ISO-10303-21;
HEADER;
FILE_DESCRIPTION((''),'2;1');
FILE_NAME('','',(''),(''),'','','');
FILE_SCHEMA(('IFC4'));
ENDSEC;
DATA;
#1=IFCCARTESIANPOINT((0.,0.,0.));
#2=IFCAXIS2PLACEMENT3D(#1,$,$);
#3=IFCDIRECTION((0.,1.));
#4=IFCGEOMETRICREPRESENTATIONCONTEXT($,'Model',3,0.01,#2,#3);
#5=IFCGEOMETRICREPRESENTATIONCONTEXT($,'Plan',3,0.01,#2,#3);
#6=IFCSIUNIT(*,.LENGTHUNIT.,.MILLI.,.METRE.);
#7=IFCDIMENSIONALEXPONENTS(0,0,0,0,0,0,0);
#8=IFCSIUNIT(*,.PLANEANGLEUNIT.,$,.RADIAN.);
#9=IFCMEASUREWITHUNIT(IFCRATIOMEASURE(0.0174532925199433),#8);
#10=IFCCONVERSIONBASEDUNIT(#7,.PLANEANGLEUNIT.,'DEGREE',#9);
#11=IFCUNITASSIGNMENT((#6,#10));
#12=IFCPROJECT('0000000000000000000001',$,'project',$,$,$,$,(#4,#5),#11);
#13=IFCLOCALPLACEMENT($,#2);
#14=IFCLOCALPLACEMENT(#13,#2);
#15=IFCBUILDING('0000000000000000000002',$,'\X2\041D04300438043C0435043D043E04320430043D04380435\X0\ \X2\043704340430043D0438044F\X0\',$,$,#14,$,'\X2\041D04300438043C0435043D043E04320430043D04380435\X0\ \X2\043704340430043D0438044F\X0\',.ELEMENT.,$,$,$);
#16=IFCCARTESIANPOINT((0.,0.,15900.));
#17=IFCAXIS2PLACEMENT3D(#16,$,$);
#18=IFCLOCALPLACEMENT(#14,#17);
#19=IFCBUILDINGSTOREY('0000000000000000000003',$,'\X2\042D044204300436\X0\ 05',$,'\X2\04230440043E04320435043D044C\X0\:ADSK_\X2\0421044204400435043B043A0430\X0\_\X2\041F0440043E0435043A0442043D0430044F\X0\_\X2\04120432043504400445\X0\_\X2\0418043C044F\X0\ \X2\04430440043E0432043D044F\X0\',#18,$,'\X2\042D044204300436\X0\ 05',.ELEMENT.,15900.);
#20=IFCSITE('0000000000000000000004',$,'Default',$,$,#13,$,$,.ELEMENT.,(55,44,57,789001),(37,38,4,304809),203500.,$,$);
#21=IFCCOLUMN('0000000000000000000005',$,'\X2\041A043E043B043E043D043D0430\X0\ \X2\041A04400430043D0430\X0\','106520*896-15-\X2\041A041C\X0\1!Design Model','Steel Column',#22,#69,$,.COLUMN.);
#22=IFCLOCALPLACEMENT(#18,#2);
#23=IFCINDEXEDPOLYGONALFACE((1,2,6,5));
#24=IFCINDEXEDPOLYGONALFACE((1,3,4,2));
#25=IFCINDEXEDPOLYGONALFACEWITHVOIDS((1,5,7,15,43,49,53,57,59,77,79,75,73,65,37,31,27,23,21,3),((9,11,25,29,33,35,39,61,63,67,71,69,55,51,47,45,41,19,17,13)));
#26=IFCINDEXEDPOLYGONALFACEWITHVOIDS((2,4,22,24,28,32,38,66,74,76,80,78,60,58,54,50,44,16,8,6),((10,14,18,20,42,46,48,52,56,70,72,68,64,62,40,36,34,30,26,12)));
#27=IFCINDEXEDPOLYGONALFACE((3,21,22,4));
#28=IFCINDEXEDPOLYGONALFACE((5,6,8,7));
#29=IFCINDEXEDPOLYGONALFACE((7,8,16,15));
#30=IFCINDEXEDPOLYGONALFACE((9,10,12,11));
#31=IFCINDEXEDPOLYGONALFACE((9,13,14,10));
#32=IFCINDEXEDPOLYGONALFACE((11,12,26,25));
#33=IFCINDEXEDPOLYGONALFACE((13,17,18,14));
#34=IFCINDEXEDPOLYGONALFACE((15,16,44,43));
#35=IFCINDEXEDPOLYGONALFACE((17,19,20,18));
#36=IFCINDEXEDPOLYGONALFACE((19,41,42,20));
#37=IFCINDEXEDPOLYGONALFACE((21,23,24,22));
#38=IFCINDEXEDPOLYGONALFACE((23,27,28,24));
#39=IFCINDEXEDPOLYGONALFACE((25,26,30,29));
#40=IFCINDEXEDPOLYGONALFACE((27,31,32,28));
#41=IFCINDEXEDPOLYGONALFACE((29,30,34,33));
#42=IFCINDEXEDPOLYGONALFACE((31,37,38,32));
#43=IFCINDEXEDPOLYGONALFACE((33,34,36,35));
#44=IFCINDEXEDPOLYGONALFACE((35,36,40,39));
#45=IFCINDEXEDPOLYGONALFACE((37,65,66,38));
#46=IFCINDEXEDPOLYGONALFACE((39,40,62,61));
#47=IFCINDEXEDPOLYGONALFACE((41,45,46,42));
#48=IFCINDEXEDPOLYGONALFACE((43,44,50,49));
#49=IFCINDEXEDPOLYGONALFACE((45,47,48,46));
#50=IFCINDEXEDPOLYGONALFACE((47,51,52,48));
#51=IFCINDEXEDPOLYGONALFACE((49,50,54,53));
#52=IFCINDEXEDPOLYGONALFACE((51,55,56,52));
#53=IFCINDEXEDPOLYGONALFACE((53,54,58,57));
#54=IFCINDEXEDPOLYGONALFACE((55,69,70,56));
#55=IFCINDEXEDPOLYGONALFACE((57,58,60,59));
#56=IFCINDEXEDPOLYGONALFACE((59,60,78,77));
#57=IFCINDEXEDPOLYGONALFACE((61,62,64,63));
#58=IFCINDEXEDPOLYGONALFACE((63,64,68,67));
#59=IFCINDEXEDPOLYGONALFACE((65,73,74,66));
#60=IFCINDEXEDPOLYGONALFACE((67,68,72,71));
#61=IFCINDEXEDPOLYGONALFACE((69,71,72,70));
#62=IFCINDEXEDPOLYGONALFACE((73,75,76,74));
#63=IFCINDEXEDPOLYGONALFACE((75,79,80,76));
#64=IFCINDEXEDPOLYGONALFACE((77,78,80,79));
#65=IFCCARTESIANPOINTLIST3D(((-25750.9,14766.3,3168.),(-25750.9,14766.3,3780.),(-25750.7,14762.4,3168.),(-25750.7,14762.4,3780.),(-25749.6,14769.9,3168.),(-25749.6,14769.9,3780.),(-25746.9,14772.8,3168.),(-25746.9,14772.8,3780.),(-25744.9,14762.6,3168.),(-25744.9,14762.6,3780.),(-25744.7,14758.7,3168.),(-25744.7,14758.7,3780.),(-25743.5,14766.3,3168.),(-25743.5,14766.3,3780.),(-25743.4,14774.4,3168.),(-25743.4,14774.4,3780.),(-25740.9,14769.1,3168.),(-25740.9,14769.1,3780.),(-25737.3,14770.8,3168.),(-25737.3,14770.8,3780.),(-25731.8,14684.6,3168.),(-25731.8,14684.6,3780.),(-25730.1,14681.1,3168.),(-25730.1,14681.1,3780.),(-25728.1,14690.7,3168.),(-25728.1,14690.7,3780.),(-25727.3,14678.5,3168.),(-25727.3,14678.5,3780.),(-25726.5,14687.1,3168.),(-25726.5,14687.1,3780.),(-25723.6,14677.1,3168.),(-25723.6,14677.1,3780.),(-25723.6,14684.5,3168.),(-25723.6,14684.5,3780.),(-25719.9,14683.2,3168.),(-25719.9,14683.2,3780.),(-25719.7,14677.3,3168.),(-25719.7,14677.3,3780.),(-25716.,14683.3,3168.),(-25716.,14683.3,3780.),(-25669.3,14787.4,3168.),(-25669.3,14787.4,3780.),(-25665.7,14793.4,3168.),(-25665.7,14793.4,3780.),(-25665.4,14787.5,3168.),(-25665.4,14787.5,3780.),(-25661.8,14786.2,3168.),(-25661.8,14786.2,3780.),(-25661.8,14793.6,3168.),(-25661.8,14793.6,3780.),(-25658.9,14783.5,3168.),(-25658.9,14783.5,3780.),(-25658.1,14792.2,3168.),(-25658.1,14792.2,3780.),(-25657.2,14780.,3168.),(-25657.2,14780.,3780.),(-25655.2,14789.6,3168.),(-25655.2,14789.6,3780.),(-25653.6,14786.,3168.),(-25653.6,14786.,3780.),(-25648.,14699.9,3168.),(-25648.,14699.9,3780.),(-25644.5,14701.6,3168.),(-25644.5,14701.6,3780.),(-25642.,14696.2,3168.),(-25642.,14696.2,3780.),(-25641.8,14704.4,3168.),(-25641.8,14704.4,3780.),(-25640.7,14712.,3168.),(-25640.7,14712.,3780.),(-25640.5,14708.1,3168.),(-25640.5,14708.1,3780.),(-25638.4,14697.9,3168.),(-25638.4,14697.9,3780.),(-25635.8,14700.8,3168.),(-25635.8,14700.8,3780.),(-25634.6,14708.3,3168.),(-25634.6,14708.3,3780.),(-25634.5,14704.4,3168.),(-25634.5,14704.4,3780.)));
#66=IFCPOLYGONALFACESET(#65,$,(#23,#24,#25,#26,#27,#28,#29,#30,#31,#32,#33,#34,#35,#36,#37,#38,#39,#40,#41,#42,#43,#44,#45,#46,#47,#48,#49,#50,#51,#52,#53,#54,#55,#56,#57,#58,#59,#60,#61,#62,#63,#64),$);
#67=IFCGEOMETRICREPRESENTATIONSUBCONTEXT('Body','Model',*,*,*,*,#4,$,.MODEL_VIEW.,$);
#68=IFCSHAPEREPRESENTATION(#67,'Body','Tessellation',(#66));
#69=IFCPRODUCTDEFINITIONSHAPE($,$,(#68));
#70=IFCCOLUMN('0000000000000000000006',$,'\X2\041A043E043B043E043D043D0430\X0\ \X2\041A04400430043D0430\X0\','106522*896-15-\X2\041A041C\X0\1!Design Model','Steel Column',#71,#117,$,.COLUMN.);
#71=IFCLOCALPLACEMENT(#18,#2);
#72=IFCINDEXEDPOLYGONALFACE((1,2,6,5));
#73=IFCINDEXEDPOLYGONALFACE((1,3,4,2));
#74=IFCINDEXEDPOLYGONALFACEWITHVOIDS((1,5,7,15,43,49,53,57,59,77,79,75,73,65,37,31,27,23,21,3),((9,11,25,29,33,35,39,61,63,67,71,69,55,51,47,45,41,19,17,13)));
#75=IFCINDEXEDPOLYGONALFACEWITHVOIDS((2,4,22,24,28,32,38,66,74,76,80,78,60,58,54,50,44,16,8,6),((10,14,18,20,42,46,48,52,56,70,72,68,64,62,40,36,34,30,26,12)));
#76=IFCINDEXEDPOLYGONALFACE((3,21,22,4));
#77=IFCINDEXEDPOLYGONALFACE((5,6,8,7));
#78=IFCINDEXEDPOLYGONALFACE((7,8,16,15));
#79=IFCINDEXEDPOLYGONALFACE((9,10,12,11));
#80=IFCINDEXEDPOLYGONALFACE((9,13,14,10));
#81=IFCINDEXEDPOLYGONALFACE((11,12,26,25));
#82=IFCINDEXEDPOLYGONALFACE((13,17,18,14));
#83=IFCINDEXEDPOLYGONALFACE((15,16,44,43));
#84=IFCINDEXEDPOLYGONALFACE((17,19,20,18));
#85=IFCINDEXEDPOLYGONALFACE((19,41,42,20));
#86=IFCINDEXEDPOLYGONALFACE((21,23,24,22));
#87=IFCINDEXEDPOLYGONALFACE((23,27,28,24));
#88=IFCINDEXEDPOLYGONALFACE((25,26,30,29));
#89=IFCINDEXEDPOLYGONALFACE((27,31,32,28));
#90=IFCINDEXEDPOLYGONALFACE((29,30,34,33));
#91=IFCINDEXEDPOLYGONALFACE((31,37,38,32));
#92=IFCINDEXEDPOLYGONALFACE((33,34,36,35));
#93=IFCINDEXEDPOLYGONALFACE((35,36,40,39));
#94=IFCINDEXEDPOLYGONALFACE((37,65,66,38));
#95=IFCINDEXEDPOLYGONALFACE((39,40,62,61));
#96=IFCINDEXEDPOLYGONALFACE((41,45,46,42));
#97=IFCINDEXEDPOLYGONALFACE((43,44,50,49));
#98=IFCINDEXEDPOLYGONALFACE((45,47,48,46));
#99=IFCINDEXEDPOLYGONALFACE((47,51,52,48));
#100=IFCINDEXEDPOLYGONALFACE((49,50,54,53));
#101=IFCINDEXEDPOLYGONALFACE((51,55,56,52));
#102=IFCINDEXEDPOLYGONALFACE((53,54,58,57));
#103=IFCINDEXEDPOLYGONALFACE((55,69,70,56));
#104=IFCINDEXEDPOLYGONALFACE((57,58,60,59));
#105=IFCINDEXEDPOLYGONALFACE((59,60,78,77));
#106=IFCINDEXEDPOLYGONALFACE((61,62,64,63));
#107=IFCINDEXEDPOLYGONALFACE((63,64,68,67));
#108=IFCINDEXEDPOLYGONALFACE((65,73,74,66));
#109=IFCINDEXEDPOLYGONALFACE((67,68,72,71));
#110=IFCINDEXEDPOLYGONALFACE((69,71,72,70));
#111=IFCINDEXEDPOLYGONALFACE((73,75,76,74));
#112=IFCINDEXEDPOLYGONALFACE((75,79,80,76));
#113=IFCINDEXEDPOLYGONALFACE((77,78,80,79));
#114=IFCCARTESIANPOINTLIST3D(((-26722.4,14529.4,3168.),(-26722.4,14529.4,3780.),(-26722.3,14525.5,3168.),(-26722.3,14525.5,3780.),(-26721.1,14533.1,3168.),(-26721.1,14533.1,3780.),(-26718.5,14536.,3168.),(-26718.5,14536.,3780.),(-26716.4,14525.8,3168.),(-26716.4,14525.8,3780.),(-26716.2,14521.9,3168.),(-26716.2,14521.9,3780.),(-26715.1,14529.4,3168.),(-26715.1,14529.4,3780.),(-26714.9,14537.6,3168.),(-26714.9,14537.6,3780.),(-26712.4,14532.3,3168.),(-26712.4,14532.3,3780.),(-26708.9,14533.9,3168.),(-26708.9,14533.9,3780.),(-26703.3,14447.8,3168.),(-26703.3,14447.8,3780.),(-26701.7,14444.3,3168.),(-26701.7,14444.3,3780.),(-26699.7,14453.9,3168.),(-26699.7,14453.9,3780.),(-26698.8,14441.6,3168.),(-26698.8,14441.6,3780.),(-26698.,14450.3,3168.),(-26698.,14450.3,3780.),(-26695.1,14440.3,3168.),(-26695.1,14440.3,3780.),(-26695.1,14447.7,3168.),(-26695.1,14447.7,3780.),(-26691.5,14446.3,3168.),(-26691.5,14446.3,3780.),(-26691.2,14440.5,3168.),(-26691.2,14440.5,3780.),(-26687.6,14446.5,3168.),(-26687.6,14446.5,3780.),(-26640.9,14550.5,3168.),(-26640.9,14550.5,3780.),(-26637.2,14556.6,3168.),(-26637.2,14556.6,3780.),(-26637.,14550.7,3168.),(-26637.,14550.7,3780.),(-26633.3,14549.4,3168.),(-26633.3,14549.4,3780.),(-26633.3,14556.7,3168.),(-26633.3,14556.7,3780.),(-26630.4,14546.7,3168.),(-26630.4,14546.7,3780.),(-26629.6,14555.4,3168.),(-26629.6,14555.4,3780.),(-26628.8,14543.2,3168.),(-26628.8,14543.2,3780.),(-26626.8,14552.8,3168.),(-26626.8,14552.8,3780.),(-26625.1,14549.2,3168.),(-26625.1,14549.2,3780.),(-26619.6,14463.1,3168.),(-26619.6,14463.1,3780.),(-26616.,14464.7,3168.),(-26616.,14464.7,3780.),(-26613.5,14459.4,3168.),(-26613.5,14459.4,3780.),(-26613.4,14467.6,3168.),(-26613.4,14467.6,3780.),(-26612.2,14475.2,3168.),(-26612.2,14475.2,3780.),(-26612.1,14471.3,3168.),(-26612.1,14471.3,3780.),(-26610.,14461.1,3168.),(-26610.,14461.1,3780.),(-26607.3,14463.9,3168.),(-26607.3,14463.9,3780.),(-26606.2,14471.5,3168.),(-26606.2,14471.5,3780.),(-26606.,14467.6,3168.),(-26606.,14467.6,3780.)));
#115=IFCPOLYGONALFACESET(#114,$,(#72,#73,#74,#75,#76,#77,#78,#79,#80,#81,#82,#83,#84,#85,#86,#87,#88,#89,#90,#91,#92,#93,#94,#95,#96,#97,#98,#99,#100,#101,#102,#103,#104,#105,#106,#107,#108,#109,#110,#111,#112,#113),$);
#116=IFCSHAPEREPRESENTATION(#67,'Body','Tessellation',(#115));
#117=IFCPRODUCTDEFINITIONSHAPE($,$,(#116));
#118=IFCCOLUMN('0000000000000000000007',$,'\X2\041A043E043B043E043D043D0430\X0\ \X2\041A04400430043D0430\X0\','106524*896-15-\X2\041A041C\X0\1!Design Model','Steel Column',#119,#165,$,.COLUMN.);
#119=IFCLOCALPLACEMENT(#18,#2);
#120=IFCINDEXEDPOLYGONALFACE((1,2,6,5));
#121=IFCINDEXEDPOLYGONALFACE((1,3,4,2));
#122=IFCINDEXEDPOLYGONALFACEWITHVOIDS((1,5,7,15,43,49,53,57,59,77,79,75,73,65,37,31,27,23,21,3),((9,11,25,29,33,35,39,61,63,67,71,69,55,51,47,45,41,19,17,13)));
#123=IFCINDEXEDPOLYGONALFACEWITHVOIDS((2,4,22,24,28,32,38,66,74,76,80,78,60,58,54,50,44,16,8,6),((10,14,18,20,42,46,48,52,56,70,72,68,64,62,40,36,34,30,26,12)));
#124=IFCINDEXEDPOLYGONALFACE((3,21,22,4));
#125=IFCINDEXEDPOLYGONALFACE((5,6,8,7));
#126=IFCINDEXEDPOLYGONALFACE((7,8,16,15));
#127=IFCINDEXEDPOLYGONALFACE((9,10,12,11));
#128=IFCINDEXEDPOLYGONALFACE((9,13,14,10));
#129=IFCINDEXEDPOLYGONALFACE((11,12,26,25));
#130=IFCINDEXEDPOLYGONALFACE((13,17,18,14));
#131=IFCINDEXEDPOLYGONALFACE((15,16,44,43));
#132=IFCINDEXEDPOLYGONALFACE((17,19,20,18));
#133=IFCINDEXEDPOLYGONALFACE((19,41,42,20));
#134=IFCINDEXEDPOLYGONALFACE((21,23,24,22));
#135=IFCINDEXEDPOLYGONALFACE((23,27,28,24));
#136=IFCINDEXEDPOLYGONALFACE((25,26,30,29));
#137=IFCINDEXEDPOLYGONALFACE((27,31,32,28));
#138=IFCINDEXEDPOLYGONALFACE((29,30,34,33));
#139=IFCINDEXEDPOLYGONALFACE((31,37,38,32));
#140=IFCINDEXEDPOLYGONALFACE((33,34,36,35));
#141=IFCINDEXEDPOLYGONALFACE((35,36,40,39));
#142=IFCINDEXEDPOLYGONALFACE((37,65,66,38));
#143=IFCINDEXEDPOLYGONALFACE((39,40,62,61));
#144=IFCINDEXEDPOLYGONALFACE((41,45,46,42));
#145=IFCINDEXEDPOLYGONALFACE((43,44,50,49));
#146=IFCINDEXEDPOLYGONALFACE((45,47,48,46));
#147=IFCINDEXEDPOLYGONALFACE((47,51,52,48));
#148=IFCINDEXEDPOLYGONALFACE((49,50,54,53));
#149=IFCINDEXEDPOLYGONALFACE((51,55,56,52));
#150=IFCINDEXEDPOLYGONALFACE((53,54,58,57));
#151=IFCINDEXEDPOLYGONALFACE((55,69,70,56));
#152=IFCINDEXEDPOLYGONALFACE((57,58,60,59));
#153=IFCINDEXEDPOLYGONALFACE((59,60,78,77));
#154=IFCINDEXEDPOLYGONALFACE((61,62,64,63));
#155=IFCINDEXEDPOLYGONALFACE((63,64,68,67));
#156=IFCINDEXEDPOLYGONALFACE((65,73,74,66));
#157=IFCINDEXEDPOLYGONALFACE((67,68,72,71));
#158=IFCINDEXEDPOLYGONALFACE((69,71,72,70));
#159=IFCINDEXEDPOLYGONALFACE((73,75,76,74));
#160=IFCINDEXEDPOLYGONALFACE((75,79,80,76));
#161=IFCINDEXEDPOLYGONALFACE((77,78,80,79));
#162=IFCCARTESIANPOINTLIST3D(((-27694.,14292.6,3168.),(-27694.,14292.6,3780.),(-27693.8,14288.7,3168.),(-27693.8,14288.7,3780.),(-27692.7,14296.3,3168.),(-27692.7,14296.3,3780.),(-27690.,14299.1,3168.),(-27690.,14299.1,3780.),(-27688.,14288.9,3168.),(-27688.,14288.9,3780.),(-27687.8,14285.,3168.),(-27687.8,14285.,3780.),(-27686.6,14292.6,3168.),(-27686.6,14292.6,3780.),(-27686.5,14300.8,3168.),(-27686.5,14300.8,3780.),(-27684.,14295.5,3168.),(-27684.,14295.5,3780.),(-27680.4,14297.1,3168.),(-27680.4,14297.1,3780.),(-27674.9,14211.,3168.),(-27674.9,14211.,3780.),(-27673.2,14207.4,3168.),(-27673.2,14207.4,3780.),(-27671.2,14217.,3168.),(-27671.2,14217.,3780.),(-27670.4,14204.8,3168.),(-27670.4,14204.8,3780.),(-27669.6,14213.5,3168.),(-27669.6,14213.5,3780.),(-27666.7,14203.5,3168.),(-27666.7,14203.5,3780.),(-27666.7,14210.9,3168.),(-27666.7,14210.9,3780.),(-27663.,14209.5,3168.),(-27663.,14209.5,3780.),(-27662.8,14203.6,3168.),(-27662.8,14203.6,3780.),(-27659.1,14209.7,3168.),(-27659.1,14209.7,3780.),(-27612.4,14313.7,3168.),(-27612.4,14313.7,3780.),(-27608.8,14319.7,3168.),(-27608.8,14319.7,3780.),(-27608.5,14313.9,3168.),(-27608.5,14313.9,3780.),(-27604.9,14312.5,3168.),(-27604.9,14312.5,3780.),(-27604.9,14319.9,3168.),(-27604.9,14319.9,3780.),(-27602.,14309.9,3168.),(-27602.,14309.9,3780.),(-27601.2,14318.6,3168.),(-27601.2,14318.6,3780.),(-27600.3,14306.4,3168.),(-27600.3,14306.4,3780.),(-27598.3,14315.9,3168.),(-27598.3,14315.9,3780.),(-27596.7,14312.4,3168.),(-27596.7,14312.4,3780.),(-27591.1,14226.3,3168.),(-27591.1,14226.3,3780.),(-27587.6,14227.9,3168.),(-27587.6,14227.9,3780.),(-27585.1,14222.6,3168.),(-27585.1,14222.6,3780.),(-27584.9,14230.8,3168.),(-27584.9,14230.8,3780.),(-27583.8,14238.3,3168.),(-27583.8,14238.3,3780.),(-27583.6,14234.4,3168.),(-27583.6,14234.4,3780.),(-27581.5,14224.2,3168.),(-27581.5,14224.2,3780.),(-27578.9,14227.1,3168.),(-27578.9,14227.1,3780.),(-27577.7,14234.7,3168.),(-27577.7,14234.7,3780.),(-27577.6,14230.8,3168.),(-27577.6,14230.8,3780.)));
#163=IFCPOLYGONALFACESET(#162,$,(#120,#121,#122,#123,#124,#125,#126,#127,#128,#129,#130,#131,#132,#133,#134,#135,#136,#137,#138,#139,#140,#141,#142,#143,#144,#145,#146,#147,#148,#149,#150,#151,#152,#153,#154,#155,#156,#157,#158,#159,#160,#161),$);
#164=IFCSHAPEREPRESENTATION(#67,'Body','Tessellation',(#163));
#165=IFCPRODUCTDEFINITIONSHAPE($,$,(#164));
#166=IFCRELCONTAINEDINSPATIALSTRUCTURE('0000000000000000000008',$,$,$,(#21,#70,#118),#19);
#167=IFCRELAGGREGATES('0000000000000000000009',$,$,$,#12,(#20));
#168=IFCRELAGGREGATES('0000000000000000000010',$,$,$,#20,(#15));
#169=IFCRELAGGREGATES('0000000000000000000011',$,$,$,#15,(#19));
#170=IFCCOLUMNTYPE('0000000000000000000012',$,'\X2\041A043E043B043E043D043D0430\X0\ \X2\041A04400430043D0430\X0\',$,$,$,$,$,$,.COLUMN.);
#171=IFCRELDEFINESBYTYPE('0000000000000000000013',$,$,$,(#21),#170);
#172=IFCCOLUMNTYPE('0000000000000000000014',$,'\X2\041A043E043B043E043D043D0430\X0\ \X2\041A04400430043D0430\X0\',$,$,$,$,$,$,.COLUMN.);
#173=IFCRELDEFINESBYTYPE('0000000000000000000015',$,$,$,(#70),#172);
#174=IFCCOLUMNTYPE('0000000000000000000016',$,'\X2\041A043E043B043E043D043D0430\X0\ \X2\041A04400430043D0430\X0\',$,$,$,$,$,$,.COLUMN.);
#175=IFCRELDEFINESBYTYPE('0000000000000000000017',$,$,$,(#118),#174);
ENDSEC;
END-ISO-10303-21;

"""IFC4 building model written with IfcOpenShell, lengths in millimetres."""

from ifc_helpers import new_model, entity, si_unit, converted_unit, direction, frame, origin, place, context, subcontext, project, spatial, indexed_curve, outline, extrude, type_object, element, save


model = new_model("IFC4")

# Units and contexts
model_context = context("Model", 3, precision=0.01, world=origin(), true_north=direction((0.0, 1.0)))
plan_context = context("Plan", 3, precision=0.01, world=origin(), true_north=direction((0.0, 1.0)))
body_context = subcontext(model_context, "Body", "Model", "MODEL_VIEW")
ifc_project = project(units=[si_unit("LENGTHUNIT", "METRE", prefix="MILLI"), converted_unit("PLANEANGLEUNIT", "DEGREE", entity("IfcRatioMeasure", 0.0174532925199433), si_unit("PLANEANGLEUNIT", "RADIAN"), dimensions=[0, 0, 0, 0, 0, 0, 0])], contexts=[model_context, plan_context])

# Site, building, storey
site_placement = place(None, origin())
site = spatial("IfcSite", under=ifc_project, at=site_placement, Name="Default", CompositionType="ELEMENT", RefLatitude=(55, 44, 57, 789001), RefLongitude=(37, 38, 4, 304809), RefElevation=203500.0)
building_placement = place(site_placement, origin())
building = spatial("IfcBuilding", under=site, at=building_placement, Name="Наименование здания", LongName="Наименование здания", CompositionType="ELEMENT")
storey_placement = place(building_placement, frame((0.0, 0.0, 15900.0)))
storey = spatial("IfcBuildingStorey", under=building, at=storey_placement, Name="Этаж 05", ObjectType="Уровень:ADSK_Стрелка_Проектная_Вверх_Имя уровня", LongName="Этаж 05", CompositionType="ELEMENT", Elevation=15900.0)

# Columns
column_type_1 = type_object("IfcColumnType", Name="Колонна Крана", PredefinedType="COLUMN")
column_1_placement = place(storey_placement, origin())
element("IfcColumn", 1, at=column_1_placement, inside=storey, type_object=column_type_1, Name="Колонна Крана", Description="106520*896-15-КМ1!Design Model", ObjectType="Steel Column", PredefinedType="COLUMN", context=body_context, shape_type="SweptSolid", body=[
    extrude(outline(indexed_curve([(29.5, -56.8), (33.4, -56.8), (37.0, -55.3), (39.7, -52.6), (41.2, -49.0), (56.8, 29.5), (56.8, 33.4), (55.3, 37.0), (52.6, 39.7), (49.0, 41.2), (-29.5, 56.8), (-33.4, 56.8), (-37.0, 55.3), (-39.7, 52.6), (-41.2, 49.0), (-56.8, -29.5), (-56.8, -33.4), (-55.3, -37.0), (-52.6, -39.7), (-49.0, -41.2), (29.5, -56.8)], self_intersect=False), holes=[indexed_curve([(-43.1, -37.3), (-46.7, -35.8), (-49.5, -33.1), (-51.0, -29.5), (-51.0, -25.5), (-37.3, 43.1), (-35.8, 46.7), (-33.1, 49.5), (-29.5, 51.0), (-25.5, 51.0), (43.1, 37.3), (46.7, 35.8), (49.5, 33.1), (51.0, 29.5), (51.0, 25.5), (37.3, -43.1), (35.8, -46.7), (33.1, -49.5), (29.5, -51.0), (25.5, -51.0), (-43.1, -37.3)], self_intersect=False)]), frame((-25692.7, 14735.3, 3168.0), z_axis=(0.0, 0.0, 1.0), x_axis=(0.906681, 0.421816, 0.0)), (0.0, 0.0, 1.0), 612.0),
])
column_type_2 = type_object("IfcColumnType", Name="Колонна Крана", PredefinedType="COLUMN")
column_2_placement = place(storey_placement, origin())
element("IfcColumn", 2, at=column_2_placement, inside=storey, type_object=column_type_2, Name="Колонна Крана", Description="106522*896-15-КМ1!Design Model", ObjectType="Steel Column", PredefinedType="COLUMN", context=body_context, shape_type="SweptSolid", body=[
    extrude(outline(indexed_curve([(29.5, -56.8), (33.4, -56.8), (37.0, -55.3), (39.7, -52.6), (41.2, -49.0), (56.8, 29.5), (56.8, 33.4), (55.3, 37.0), (52.6, 39.7), (49.0, 41.2), (-29.5, 56.8), (-33.4, 56.8), (-37.0, 55.3), (-39.7, 52.6), (-41.2, 49.0), (-56.8, -29.5), (-56.8, -33.4), (-55.3, -37.0), (-52.6, -39.7), (-49.0, -41.2), (29.5, -56.8)], self_intersect=False), holes=[indexed_curve([(-43.1, -37.3), (-46.7, -35.8), (-49.5, -33.1), (-51.0, -29.5), (-51.0, -25.5), (-37.3, 43.1), (-35.8, 46.7), (-33.1, 49.5), (-29.5, 51.0), (-25.5, 51.0), (43.1, 37.3), (46.7, 35.8), (49.5, 33.1), (51.0, 29.5), (51.0, 25.5), (37.3, -43.1), (35.8, -46.7), (33.1, -49.5), (29.5, -51.0), (25.5, -51.0), (-43.1, -37.3)], self_intersect=False)]), frame((-26664.2, 14498.5, 3168.0), z_axis=(0.0, 0.0, 1.0), x_axis=(0.906681, 0.421816, 0.0)), (0.0, 0.0, 1.0), 612.0),
])
column_type_3 = type_object("IfcColumnType", Name="Колонна Крана", PredefinedType="COLUMN")
column_3_placement = place(storey_placement, origin())
element("IfcColumn", 3, at=column_3_placement, inside=storey, type_object=column_type_3, Name="Колонна Крана", Description="106524*896-15-КМ1!Design Model", ObjectType="Steel Column", PredefinedType="COLUMN", context=body_context, shape_type="SweptSolid", body=[
    extrude(outline(indexed_curve([(29.5, -56.8), (33.4, -56.8), (37.0, -55.3), (39.7, -52.6), (41.2, -49.0), (56.8, 29.5), (56.8, 33.4), (55.3, 37.0), (52.6, 39.7), (49.0, 41.2), (-29.5, 56.8), (-33.4, 56.8), (-37.0, 55.3), (-39.7, 52.6), (-41.2, 49.0), (-56.8, -29.5), (-56.8, -33.4), (-55.3, -37.0), (-52.6, -39.7), (-49.0, -41.2), (29.5, -56.8)], self_intersect=False), holes=[indexed_curve([(-43.1, -37.3), (-46.7, -35.8), (-49.5, -33.1), (-51.0, -29.5), (-51.0, -25.5), (-37.3, 43.1), (-35.8, 46.7), (-33.1, 49.5), (-29.5, 51.0), (-25.5, 51.0), (43.1, 37.3), (46.7, 35.8), (49.5, 33.1), (51.0, 29.5), (51.0, 25.5), (37.3, -43.1), (35.8, -46.7), (33.1, -49.5), (29.5, -51.0), (25.5, -51.0), (-43.1, -37.3)], self_intersect=False)]), frame((-27635.8, 14261.7, 3168.0), z_axis=(0.0, 0.0, 1.0), x_axis=(0.906681, 0.421816, 0.0)), (0.0, 0.0, 1.0), 612.0),
])

save(model, "model.ifc")
